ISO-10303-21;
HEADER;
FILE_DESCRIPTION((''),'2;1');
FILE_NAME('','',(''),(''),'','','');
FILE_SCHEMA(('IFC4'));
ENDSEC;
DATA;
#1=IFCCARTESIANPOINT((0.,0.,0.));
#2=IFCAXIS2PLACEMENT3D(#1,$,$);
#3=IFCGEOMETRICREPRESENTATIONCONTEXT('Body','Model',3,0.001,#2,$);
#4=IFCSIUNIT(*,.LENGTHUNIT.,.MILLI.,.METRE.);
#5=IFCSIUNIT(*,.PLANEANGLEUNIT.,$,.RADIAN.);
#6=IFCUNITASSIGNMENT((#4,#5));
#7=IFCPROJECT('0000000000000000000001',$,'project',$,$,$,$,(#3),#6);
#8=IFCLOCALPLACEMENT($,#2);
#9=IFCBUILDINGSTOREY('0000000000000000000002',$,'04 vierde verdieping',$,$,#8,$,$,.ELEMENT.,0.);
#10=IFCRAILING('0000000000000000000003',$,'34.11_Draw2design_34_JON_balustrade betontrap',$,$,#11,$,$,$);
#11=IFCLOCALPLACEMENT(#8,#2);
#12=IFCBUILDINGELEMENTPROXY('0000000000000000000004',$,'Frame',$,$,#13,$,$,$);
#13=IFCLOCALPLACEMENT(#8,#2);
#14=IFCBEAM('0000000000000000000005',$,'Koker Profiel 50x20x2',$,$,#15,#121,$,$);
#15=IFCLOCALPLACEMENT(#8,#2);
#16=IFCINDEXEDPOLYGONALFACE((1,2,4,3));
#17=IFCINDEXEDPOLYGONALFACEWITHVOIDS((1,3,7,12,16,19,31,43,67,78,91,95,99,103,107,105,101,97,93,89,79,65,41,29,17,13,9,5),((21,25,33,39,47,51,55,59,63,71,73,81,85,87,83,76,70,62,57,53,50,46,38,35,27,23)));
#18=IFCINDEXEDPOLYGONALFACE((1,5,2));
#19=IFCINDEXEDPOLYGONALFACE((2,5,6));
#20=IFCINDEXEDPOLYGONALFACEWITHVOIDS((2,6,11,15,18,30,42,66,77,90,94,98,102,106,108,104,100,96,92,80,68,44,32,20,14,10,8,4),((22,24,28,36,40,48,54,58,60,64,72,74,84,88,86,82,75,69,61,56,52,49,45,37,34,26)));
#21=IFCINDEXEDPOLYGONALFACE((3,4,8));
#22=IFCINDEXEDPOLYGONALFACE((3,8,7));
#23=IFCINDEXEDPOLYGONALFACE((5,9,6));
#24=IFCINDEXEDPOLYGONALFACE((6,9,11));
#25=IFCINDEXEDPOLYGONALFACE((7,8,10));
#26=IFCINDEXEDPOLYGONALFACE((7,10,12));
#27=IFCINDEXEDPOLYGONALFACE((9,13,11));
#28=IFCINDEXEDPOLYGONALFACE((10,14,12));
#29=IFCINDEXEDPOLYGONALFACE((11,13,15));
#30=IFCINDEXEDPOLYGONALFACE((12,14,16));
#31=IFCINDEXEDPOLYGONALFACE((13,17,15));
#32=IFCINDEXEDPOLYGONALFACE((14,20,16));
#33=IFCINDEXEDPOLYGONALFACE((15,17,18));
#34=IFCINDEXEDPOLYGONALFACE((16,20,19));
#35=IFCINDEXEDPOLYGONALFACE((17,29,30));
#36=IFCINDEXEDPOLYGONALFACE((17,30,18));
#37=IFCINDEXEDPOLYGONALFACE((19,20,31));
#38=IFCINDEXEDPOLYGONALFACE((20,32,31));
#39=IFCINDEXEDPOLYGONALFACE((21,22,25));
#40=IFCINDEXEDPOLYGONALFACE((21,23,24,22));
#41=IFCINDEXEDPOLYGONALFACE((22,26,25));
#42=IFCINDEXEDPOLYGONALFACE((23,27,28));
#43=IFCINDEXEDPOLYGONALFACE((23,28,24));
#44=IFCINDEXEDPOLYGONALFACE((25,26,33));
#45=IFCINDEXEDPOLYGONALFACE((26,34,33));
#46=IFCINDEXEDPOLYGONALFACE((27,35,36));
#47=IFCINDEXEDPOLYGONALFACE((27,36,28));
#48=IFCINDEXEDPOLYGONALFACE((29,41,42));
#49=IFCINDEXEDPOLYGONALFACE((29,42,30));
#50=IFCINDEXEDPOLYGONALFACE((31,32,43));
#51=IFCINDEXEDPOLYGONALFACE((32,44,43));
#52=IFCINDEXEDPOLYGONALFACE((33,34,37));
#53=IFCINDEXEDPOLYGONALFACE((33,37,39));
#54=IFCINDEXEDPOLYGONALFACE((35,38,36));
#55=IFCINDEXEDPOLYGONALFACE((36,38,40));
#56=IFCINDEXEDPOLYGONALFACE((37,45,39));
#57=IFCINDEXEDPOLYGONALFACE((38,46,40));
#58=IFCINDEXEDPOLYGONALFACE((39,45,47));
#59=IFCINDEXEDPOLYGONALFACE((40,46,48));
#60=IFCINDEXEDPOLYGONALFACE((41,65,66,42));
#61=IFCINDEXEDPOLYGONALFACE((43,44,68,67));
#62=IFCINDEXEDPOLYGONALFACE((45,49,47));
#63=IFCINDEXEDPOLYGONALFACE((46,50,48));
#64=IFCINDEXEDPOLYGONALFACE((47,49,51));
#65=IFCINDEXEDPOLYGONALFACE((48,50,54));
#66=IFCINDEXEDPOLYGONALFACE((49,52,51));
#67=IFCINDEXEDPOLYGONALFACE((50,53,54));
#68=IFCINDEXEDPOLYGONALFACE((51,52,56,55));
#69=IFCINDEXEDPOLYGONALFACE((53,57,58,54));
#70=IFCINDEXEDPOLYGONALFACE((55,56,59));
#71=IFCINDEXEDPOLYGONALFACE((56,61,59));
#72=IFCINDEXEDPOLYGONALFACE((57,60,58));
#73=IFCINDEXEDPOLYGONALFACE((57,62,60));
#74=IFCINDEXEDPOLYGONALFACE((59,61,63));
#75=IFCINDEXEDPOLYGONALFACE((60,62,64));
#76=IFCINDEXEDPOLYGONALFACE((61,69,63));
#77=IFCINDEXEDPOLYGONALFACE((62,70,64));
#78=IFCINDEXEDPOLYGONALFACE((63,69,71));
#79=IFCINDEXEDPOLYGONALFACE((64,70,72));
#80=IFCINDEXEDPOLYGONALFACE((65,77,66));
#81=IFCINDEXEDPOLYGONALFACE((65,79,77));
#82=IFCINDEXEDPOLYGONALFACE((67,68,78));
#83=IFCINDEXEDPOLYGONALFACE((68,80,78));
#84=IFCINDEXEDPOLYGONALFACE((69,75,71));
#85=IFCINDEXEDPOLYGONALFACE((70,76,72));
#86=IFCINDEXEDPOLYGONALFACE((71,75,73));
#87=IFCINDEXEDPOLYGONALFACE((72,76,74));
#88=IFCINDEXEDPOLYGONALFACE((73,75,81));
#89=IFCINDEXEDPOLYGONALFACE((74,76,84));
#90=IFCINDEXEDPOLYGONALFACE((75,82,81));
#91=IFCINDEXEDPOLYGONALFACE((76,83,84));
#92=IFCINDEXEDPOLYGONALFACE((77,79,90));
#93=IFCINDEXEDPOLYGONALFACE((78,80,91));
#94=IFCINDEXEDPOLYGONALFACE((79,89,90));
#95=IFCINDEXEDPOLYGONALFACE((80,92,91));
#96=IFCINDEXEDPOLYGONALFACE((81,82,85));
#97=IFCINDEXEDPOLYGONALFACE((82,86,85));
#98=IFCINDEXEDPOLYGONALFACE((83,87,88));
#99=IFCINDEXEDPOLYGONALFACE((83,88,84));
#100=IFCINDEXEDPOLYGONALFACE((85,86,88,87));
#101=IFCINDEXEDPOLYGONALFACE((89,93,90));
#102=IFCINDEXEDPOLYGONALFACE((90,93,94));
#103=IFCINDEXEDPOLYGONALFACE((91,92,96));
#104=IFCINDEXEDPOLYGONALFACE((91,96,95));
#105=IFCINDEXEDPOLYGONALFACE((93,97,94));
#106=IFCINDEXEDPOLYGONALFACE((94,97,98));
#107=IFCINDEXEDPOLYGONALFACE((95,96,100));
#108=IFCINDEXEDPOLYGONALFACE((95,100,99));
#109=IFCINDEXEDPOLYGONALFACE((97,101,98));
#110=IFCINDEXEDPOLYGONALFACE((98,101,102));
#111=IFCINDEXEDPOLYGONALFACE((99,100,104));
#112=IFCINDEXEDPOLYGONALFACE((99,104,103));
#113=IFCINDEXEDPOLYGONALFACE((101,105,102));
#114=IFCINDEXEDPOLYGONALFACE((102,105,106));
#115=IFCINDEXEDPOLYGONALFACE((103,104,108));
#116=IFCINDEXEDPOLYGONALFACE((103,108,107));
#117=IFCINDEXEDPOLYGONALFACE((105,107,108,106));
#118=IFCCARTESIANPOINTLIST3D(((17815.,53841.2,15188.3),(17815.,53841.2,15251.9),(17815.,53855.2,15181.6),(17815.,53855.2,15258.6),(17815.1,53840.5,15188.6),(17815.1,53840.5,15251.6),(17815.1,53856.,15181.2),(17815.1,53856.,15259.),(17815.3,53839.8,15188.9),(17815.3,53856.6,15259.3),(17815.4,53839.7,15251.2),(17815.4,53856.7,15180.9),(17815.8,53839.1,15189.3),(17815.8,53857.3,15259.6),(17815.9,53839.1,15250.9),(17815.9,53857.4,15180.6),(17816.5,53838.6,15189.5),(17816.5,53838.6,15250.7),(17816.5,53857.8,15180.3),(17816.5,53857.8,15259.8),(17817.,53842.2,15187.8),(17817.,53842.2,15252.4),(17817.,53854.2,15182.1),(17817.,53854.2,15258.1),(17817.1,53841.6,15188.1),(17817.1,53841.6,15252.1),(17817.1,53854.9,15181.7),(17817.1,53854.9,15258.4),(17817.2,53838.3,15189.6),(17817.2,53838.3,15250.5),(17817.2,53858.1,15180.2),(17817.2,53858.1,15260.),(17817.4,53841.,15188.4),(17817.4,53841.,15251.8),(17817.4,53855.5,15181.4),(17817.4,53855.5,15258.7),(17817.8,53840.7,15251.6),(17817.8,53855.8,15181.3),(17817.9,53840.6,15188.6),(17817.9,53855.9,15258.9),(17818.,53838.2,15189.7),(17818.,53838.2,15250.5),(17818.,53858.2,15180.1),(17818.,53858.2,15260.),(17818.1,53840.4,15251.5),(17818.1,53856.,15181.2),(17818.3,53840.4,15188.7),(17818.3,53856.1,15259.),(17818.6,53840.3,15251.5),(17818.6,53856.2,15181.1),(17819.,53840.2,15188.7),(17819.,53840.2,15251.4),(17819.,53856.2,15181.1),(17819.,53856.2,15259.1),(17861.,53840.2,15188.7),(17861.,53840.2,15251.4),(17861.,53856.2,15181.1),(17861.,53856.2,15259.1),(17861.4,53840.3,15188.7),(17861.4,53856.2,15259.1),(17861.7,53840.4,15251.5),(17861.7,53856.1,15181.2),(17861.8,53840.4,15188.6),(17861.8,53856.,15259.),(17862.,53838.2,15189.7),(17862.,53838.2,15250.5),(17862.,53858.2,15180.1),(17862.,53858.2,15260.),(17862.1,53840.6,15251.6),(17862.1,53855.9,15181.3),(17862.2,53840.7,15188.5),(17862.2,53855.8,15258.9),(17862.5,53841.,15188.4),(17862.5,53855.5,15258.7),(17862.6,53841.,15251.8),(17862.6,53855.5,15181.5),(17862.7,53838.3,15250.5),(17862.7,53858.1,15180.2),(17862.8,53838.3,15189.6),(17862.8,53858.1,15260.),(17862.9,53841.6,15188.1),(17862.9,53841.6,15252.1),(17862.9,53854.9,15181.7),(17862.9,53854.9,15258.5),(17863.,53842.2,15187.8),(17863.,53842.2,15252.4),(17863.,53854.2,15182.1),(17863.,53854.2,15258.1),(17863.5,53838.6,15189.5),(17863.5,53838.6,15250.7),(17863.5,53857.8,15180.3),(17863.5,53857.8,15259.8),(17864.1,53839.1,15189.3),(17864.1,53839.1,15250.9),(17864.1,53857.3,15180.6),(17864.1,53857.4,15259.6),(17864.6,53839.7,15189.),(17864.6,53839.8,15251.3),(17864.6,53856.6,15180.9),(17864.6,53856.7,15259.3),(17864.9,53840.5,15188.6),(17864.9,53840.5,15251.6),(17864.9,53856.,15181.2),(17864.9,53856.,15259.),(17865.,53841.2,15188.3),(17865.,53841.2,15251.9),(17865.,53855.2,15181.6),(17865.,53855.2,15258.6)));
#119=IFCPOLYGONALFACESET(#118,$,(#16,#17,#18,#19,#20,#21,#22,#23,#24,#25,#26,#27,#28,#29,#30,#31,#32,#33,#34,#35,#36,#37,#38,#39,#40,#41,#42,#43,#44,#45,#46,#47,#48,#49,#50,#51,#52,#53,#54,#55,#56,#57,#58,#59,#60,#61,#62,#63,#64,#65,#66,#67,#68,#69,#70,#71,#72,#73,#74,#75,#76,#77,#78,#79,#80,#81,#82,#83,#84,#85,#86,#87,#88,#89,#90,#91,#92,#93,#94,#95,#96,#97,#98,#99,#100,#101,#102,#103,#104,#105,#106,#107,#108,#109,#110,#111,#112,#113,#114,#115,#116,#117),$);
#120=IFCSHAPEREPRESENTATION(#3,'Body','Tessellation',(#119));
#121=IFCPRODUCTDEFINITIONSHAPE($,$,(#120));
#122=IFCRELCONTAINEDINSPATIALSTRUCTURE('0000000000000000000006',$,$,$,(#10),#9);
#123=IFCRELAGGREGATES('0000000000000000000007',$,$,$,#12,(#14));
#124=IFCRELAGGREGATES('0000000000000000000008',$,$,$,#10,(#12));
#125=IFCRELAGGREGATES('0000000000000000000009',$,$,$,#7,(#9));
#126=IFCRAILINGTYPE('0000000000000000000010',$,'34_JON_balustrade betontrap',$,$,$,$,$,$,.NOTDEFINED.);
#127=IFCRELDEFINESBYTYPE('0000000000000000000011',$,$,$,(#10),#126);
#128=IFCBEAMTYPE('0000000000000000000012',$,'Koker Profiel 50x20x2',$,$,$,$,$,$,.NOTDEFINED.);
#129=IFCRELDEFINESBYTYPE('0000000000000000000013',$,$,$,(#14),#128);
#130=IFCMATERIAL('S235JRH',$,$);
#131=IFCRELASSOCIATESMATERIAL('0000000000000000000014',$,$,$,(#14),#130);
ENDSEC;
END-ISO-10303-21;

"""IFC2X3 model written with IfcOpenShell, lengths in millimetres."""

from ifc_helpers import new_model, si_unit, frame, origin, origin_2d, place, context, project, spatial, hollow_rectangle, extrude, clip, halfspace, source, transform, mapped, material, type_object, element, aggregate, save


model = new_model("IFC2X3")

# Units and contexts
model_context = context("Model", 3, precision=0.001, world=origin(), identifier="Body")
ifc_project = project(units=[si_unit("LENGTHUNIT", "METRE", prefix="MILLI"), si_unit("PLANEANGLEUNIT", "RADIAN")], contexts=[model_context])

# Storey
storey_placement = place(None, origin())
storey = spatial("IfcBuildingStorey", under=ifc_project, at=storey_placement, Name="04 vierde verdieping", CompositionType="ELEMENT", Elevation=0.0)

# Railing, building element proxy
railing_type = type_object("IfcRailingType", Name="34_JON_balustrade betontrap")
railing_1_placement = place(storey_placement, frame((-2939.5, 7875.7, -33704.2), z_axis=(0.0, 0.0, 1.0), x_axis=(1.0, 0.0, 0.0)))
railing_1 = element("IfcRailing", 1, at=railing_1_placement, inside=storey, type_object=railing_type, Name="34.11_Draw2design_34_JON_balustrade betontrap")
ifc_material_1 = material(Name="S235JRH")
proxy_1_placement = place(railing_1_placement, origin())
proxy_1 = element("IfcBuildingElementProxy", 2, at=proxy_1_placement, Name="Frame")
beam_type_1 = type_object("IfcBeamType", Name="Koker Profiel 50x20x2")

# Beam
shared_shape_1 = source(origin(), model_context, "Body", "Clipping", [
    clip(clip(extrude(hollow_rectangle(XDim=20.0, YDim=50.0, WallThickness=2.0, InnerFilletRadius=2.0, OuterFilletRadius=3.0, at=origin_2d()), origin(), (0.0, 0.0, -1.0), 79.9), halfspace(frame((-10.0, 25.0, -9.6), z_axis=(-0.430948, 0.0, 0.902377), x_axis=(0.902377, 0.0, 0.430948)), False)), halfspace(frame((-10.0, -25.0, -70.3), z_axis=(-0.430948, 0.0, -0.902377), x_axis=(-0.902377, 0.0, 0.430948)), False)),
])
beam_1_placement = place(proxy_1_placement, frame((20779.5, 45972.5, 48964.2), z_axis=(0.0, 0.0, 1.0), x_axis=(0.0, 1.0, 0.0)))
beam_1 = element("IfcBeam", 3, at=beam_1_placement, type_object=beam_type_1, material=ifc_material_1, Name="Koker Profiel 50x20x2", context=model_context, shape_type="MappedRepresentation", body=[
    mapped(shared_shape_1, transform((0.0, 0.0, 0.0), scale=1.0)),
])
aggregate(proxy_1, [beam_1])

aggregate(railing_1, [proxy_1])

save(model, "model.ifc")
